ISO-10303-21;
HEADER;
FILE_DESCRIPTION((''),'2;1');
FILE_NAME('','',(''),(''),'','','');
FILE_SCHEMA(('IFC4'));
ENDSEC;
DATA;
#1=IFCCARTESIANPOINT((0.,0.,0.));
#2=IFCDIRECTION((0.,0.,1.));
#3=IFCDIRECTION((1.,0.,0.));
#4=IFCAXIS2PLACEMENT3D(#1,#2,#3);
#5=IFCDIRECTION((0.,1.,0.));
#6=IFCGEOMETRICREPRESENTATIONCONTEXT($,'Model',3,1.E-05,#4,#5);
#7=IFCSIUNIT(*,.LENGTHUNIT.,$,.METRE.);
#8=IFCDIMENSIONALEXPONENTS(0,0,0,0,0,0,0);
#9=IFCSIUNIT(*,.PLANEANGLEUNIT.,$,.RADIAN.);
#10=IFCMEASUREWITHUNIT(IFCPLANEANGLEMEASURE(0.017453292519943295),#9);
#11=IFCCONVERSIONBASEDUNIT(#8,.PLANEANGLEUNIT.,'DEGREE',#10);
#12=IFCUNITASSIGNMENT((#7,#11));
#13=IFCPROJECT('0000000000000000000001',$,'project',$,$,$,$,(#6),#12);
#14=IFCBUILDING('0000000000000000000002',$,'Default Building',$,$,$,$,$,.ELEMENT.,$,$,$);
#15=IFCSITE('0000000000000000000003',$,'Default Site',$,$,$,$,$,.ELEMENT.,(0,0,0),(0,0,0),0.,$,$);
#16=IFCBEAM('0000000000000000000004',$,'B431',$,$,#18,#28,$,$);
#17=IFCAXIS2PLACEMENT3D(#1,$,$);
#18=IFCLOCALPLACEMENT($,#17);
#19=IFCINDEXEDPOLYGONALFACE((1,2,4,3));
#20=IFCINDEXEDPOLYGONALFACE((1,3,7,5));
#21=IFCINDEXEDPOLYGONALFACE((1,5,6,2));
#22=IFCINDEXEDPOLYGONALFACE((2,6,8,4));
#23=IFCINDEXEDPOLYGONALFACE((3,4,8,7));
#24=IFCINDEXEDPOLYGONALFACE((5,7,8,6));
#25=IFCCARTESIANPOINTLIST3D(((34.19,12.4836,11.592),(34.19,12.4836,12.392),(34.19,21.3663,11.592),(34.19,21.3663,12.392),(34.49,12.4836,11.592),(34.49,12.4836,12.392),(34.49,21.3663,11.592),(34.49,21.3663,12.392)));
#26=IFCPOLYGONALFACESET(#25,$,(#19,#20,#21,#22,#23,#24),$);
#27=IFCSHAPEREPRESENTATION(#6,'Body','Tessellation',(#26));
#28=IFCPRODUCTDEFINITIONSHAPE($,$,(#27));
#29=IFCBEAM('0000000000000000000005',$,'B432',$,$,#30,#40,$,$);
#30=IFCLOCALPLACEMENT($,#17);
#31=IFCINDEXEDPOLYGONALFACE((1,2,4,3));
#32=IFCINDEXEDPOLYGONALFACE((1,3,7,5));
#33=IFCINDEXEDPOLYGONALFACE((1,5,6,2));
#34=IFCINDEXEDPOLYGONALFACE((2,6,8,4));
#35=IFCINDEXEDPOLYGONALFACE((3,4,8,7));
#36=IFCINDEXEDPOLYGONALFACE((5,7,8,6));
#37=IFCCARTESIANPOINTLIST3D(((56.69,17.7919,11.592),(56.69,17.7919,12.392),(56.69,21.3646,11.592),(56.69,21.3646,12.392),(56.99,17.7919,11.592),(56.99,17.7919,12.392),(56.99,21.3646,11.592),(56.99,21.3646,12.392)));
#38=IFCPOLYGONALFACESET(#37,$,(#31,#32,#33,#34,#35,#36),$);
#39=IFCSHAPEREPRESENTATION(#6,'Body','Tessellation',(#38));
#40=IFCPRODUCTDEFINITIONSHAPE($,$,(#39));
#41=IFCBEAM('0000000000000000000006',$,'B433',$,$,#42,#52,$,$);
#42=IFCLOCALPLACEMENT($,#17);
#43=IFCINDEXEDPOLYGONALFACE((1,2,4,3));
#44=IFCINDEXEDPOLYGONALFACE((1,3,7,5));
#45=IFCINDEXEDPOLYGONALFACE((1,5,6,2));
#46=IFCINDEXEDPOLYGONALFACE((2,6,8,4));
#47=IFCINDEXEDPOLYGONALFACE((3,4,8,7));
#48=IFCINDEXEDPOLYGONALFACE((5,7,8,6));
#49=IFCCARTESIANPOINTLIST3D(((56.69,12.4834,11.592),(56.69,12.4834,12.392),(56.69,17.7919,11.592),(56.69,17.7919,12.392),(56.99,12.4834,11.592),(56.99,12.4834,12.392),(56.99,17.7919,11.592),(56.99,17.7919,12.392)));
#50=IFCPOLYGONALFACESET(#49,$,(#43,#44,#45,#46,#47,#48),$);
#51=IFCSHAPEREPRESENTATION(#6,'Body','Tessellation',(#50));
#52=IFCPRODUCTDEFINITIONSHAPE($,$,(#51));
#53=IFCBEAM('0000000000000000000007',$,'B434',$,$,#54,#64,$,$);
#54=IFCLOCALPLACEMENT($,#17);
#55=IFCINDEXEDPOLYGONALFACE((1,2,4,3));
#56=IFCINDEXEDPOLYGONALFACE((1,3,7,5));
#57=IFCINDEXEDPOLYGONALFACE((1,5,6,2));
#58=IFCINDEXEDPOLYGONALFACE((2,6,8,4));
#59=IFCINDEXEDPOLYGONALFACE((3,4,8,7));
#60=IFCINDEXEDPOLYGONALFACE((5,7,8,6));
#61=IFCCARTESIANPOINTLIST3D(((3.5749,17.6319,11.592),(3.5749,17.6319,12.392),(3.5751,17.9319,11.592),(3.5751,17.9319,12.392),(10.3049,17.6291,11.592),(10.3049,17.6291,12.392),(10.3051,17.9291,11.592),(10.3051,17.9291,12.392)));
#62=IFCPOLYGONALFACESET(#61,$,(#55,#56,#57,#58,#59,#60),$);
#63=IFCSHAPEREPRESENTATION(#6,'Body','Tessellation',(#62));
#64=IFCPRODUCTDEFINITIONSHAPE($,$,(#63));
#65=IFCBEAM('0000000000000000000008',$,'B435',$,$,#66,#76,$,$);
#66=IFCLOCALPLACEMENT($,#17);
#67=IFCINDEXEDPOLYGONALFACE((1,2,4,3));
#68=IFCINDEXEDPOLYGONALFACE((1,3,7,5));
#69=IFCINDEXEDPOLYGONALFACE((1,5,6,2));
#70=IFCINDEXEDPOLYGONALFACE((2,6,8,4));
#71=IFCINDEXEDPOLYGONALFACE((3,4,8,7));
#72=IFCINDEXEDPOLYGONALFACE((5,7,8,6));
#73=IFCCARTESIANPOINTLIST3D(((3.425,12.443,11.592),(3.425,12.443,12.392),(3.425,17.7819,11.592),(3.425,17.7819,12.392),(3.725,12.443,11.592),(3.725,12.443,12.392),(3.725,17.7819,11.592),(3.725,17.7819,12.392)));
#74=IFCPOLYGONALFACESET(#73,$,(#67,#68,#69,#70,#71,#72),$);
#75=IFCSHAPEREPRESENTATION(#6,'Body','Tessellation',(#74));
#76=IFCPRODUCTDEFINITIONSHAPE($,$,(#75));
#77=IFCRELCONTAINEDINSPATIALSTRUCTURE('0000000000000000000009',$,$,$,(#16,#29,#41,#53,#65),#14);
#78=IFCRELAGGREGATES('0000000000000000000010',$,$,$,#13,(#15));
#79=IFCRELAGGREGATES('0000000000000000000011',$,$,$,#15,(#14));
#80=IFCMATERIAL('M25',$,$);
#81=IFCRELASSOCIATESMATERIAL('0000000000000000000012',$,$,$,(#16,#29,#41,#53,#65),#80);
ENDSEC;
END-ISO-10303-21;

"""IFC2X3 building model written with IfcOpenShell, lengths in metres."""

from ifc_helpers import new_model, entity, si_unit, converted_unit, direction, frame, frame_2d, origin_with_axes, place, context, project, spatial, rectangle, extrude, material, element, save


model = new_model("IFC2X3")

# Units and contexts
model_context = context("Model", 3, precision=1e-05, world=origin_with_axes(), true_north=direction((0.0, 1.0, 0.0)))
ifc_project = project(units=[si_unit("LENGTHUNIT", "METRE"), converted_unit("PLANEANGLEUNIT", "DEGREE", entity("IfcPlaneAngleMeasure", 0.017453292519943295), si_unit("PLANEANGLEUNIT", "RADIAN"), dimensions=[0, 0, 0, 0, 0, 0, 0])], contexts=[model_context])

# Site, building
site = spatial("IfcSite", under=ifc_project, Name="Default Site", CompositionType="ELEMENT", RefLatitude=(0, 0, 0), RefLongitude=(0, 0, 0), RefElevation=0.0)
building = spatial("IfcBuilding", under=site, Name="Default Building", CompositionType="ELEMENT")

# Beams
ifc_material = material(Name="M25")
placement = place(None, origin_with_axes())
element("IfcBeam", 1, at=placement, inside=building, material=ifc_material, Name="B431", context=model_context, shape_type="SweptSolid", body=[
    extrude(rectangle(XDim=0.3, YDim=0.8, at=frame_2d((0.0, 0.0), x_axis=(0.0, 1.0, 0.0))), frame((34.34, 12.4836, 11.992), z_axis=(0.0, 1.0, 0.0), x_axis=(0.0, 0.0, -1.0)), (0.0, 0.0, 1.0), 8.8827),
])
element("IfcBeam", 2, at=placement, inside=building, material=ifc_material, Name="B432", context=model_context, shape_type="SweptSolid", body=[
    extrude(rectangle(XDim=0.3, YDim=0.8, at=frame_2d((0.0, 0.0), x_axis=(0.0, 1.0, 0.0))), frame((56.84, 17.7919, 11.992), z_axis=(0.0, 1.0, 0.0), x_axis=(0.0, 0.0, -1.0)), (0.0, 0.0, 1.0), 3.5727),
])
element("IfcBeam", 3, at=placement, inside=building, material=ifc_material, Name="B433", context=model_context, shape_type="SweptSolid", body=[
    extrude(rectangle(XDim=0.3, YDim=0.8, at=frame_2d((0.0, 0.0), x_axis=(0.0, 1.0, 0.0))), frame((56.84, 12.4834, 11.992), z_axis=(0.0, 1.0, 0.0), x_axis=(0.0, 0.0, -1.0)), (0.0, 0.0, 1.0), 5.3085),
])
element("IfcBeam", 4, at=placement, inside=building, material=ifc_material, Name="B434", context=model_context, shape_type="SweptSolid", body=[
    extrude(rectangle(XDim=0.3, YDim=0.8, at=frame_2d((0.0, 0.0), x_axis=(0.0, 1.0, 0.0))), frame((10.305, 17.7791, 11.992), z_axis=(-1.0, 0.000419, 0.0), x_axis=(0.0, 0.0, -1.0)), (0.0, 0.0, 1.0), 6.73),
])
element("IfcBeam", 5, at=placement, inside=building, material=ifc_material, Name="B435", context=model_context, shape_type="SweptSolid", body=[
    extrude(rectangle(XDim=0.3, YDim=0.8, at=frame_2d((0.0, 0.0), x_axis=(0.0, 1.0, 0.0))), frame((3.575, 12.443, 11.992), z_axis=(0.0, 1.0, 0.0), x_axis=(0.0, 0.0, -1.0)), (0.0, 0.0, 1.0), 5.3389),
])

save(model, "model.ifc")
